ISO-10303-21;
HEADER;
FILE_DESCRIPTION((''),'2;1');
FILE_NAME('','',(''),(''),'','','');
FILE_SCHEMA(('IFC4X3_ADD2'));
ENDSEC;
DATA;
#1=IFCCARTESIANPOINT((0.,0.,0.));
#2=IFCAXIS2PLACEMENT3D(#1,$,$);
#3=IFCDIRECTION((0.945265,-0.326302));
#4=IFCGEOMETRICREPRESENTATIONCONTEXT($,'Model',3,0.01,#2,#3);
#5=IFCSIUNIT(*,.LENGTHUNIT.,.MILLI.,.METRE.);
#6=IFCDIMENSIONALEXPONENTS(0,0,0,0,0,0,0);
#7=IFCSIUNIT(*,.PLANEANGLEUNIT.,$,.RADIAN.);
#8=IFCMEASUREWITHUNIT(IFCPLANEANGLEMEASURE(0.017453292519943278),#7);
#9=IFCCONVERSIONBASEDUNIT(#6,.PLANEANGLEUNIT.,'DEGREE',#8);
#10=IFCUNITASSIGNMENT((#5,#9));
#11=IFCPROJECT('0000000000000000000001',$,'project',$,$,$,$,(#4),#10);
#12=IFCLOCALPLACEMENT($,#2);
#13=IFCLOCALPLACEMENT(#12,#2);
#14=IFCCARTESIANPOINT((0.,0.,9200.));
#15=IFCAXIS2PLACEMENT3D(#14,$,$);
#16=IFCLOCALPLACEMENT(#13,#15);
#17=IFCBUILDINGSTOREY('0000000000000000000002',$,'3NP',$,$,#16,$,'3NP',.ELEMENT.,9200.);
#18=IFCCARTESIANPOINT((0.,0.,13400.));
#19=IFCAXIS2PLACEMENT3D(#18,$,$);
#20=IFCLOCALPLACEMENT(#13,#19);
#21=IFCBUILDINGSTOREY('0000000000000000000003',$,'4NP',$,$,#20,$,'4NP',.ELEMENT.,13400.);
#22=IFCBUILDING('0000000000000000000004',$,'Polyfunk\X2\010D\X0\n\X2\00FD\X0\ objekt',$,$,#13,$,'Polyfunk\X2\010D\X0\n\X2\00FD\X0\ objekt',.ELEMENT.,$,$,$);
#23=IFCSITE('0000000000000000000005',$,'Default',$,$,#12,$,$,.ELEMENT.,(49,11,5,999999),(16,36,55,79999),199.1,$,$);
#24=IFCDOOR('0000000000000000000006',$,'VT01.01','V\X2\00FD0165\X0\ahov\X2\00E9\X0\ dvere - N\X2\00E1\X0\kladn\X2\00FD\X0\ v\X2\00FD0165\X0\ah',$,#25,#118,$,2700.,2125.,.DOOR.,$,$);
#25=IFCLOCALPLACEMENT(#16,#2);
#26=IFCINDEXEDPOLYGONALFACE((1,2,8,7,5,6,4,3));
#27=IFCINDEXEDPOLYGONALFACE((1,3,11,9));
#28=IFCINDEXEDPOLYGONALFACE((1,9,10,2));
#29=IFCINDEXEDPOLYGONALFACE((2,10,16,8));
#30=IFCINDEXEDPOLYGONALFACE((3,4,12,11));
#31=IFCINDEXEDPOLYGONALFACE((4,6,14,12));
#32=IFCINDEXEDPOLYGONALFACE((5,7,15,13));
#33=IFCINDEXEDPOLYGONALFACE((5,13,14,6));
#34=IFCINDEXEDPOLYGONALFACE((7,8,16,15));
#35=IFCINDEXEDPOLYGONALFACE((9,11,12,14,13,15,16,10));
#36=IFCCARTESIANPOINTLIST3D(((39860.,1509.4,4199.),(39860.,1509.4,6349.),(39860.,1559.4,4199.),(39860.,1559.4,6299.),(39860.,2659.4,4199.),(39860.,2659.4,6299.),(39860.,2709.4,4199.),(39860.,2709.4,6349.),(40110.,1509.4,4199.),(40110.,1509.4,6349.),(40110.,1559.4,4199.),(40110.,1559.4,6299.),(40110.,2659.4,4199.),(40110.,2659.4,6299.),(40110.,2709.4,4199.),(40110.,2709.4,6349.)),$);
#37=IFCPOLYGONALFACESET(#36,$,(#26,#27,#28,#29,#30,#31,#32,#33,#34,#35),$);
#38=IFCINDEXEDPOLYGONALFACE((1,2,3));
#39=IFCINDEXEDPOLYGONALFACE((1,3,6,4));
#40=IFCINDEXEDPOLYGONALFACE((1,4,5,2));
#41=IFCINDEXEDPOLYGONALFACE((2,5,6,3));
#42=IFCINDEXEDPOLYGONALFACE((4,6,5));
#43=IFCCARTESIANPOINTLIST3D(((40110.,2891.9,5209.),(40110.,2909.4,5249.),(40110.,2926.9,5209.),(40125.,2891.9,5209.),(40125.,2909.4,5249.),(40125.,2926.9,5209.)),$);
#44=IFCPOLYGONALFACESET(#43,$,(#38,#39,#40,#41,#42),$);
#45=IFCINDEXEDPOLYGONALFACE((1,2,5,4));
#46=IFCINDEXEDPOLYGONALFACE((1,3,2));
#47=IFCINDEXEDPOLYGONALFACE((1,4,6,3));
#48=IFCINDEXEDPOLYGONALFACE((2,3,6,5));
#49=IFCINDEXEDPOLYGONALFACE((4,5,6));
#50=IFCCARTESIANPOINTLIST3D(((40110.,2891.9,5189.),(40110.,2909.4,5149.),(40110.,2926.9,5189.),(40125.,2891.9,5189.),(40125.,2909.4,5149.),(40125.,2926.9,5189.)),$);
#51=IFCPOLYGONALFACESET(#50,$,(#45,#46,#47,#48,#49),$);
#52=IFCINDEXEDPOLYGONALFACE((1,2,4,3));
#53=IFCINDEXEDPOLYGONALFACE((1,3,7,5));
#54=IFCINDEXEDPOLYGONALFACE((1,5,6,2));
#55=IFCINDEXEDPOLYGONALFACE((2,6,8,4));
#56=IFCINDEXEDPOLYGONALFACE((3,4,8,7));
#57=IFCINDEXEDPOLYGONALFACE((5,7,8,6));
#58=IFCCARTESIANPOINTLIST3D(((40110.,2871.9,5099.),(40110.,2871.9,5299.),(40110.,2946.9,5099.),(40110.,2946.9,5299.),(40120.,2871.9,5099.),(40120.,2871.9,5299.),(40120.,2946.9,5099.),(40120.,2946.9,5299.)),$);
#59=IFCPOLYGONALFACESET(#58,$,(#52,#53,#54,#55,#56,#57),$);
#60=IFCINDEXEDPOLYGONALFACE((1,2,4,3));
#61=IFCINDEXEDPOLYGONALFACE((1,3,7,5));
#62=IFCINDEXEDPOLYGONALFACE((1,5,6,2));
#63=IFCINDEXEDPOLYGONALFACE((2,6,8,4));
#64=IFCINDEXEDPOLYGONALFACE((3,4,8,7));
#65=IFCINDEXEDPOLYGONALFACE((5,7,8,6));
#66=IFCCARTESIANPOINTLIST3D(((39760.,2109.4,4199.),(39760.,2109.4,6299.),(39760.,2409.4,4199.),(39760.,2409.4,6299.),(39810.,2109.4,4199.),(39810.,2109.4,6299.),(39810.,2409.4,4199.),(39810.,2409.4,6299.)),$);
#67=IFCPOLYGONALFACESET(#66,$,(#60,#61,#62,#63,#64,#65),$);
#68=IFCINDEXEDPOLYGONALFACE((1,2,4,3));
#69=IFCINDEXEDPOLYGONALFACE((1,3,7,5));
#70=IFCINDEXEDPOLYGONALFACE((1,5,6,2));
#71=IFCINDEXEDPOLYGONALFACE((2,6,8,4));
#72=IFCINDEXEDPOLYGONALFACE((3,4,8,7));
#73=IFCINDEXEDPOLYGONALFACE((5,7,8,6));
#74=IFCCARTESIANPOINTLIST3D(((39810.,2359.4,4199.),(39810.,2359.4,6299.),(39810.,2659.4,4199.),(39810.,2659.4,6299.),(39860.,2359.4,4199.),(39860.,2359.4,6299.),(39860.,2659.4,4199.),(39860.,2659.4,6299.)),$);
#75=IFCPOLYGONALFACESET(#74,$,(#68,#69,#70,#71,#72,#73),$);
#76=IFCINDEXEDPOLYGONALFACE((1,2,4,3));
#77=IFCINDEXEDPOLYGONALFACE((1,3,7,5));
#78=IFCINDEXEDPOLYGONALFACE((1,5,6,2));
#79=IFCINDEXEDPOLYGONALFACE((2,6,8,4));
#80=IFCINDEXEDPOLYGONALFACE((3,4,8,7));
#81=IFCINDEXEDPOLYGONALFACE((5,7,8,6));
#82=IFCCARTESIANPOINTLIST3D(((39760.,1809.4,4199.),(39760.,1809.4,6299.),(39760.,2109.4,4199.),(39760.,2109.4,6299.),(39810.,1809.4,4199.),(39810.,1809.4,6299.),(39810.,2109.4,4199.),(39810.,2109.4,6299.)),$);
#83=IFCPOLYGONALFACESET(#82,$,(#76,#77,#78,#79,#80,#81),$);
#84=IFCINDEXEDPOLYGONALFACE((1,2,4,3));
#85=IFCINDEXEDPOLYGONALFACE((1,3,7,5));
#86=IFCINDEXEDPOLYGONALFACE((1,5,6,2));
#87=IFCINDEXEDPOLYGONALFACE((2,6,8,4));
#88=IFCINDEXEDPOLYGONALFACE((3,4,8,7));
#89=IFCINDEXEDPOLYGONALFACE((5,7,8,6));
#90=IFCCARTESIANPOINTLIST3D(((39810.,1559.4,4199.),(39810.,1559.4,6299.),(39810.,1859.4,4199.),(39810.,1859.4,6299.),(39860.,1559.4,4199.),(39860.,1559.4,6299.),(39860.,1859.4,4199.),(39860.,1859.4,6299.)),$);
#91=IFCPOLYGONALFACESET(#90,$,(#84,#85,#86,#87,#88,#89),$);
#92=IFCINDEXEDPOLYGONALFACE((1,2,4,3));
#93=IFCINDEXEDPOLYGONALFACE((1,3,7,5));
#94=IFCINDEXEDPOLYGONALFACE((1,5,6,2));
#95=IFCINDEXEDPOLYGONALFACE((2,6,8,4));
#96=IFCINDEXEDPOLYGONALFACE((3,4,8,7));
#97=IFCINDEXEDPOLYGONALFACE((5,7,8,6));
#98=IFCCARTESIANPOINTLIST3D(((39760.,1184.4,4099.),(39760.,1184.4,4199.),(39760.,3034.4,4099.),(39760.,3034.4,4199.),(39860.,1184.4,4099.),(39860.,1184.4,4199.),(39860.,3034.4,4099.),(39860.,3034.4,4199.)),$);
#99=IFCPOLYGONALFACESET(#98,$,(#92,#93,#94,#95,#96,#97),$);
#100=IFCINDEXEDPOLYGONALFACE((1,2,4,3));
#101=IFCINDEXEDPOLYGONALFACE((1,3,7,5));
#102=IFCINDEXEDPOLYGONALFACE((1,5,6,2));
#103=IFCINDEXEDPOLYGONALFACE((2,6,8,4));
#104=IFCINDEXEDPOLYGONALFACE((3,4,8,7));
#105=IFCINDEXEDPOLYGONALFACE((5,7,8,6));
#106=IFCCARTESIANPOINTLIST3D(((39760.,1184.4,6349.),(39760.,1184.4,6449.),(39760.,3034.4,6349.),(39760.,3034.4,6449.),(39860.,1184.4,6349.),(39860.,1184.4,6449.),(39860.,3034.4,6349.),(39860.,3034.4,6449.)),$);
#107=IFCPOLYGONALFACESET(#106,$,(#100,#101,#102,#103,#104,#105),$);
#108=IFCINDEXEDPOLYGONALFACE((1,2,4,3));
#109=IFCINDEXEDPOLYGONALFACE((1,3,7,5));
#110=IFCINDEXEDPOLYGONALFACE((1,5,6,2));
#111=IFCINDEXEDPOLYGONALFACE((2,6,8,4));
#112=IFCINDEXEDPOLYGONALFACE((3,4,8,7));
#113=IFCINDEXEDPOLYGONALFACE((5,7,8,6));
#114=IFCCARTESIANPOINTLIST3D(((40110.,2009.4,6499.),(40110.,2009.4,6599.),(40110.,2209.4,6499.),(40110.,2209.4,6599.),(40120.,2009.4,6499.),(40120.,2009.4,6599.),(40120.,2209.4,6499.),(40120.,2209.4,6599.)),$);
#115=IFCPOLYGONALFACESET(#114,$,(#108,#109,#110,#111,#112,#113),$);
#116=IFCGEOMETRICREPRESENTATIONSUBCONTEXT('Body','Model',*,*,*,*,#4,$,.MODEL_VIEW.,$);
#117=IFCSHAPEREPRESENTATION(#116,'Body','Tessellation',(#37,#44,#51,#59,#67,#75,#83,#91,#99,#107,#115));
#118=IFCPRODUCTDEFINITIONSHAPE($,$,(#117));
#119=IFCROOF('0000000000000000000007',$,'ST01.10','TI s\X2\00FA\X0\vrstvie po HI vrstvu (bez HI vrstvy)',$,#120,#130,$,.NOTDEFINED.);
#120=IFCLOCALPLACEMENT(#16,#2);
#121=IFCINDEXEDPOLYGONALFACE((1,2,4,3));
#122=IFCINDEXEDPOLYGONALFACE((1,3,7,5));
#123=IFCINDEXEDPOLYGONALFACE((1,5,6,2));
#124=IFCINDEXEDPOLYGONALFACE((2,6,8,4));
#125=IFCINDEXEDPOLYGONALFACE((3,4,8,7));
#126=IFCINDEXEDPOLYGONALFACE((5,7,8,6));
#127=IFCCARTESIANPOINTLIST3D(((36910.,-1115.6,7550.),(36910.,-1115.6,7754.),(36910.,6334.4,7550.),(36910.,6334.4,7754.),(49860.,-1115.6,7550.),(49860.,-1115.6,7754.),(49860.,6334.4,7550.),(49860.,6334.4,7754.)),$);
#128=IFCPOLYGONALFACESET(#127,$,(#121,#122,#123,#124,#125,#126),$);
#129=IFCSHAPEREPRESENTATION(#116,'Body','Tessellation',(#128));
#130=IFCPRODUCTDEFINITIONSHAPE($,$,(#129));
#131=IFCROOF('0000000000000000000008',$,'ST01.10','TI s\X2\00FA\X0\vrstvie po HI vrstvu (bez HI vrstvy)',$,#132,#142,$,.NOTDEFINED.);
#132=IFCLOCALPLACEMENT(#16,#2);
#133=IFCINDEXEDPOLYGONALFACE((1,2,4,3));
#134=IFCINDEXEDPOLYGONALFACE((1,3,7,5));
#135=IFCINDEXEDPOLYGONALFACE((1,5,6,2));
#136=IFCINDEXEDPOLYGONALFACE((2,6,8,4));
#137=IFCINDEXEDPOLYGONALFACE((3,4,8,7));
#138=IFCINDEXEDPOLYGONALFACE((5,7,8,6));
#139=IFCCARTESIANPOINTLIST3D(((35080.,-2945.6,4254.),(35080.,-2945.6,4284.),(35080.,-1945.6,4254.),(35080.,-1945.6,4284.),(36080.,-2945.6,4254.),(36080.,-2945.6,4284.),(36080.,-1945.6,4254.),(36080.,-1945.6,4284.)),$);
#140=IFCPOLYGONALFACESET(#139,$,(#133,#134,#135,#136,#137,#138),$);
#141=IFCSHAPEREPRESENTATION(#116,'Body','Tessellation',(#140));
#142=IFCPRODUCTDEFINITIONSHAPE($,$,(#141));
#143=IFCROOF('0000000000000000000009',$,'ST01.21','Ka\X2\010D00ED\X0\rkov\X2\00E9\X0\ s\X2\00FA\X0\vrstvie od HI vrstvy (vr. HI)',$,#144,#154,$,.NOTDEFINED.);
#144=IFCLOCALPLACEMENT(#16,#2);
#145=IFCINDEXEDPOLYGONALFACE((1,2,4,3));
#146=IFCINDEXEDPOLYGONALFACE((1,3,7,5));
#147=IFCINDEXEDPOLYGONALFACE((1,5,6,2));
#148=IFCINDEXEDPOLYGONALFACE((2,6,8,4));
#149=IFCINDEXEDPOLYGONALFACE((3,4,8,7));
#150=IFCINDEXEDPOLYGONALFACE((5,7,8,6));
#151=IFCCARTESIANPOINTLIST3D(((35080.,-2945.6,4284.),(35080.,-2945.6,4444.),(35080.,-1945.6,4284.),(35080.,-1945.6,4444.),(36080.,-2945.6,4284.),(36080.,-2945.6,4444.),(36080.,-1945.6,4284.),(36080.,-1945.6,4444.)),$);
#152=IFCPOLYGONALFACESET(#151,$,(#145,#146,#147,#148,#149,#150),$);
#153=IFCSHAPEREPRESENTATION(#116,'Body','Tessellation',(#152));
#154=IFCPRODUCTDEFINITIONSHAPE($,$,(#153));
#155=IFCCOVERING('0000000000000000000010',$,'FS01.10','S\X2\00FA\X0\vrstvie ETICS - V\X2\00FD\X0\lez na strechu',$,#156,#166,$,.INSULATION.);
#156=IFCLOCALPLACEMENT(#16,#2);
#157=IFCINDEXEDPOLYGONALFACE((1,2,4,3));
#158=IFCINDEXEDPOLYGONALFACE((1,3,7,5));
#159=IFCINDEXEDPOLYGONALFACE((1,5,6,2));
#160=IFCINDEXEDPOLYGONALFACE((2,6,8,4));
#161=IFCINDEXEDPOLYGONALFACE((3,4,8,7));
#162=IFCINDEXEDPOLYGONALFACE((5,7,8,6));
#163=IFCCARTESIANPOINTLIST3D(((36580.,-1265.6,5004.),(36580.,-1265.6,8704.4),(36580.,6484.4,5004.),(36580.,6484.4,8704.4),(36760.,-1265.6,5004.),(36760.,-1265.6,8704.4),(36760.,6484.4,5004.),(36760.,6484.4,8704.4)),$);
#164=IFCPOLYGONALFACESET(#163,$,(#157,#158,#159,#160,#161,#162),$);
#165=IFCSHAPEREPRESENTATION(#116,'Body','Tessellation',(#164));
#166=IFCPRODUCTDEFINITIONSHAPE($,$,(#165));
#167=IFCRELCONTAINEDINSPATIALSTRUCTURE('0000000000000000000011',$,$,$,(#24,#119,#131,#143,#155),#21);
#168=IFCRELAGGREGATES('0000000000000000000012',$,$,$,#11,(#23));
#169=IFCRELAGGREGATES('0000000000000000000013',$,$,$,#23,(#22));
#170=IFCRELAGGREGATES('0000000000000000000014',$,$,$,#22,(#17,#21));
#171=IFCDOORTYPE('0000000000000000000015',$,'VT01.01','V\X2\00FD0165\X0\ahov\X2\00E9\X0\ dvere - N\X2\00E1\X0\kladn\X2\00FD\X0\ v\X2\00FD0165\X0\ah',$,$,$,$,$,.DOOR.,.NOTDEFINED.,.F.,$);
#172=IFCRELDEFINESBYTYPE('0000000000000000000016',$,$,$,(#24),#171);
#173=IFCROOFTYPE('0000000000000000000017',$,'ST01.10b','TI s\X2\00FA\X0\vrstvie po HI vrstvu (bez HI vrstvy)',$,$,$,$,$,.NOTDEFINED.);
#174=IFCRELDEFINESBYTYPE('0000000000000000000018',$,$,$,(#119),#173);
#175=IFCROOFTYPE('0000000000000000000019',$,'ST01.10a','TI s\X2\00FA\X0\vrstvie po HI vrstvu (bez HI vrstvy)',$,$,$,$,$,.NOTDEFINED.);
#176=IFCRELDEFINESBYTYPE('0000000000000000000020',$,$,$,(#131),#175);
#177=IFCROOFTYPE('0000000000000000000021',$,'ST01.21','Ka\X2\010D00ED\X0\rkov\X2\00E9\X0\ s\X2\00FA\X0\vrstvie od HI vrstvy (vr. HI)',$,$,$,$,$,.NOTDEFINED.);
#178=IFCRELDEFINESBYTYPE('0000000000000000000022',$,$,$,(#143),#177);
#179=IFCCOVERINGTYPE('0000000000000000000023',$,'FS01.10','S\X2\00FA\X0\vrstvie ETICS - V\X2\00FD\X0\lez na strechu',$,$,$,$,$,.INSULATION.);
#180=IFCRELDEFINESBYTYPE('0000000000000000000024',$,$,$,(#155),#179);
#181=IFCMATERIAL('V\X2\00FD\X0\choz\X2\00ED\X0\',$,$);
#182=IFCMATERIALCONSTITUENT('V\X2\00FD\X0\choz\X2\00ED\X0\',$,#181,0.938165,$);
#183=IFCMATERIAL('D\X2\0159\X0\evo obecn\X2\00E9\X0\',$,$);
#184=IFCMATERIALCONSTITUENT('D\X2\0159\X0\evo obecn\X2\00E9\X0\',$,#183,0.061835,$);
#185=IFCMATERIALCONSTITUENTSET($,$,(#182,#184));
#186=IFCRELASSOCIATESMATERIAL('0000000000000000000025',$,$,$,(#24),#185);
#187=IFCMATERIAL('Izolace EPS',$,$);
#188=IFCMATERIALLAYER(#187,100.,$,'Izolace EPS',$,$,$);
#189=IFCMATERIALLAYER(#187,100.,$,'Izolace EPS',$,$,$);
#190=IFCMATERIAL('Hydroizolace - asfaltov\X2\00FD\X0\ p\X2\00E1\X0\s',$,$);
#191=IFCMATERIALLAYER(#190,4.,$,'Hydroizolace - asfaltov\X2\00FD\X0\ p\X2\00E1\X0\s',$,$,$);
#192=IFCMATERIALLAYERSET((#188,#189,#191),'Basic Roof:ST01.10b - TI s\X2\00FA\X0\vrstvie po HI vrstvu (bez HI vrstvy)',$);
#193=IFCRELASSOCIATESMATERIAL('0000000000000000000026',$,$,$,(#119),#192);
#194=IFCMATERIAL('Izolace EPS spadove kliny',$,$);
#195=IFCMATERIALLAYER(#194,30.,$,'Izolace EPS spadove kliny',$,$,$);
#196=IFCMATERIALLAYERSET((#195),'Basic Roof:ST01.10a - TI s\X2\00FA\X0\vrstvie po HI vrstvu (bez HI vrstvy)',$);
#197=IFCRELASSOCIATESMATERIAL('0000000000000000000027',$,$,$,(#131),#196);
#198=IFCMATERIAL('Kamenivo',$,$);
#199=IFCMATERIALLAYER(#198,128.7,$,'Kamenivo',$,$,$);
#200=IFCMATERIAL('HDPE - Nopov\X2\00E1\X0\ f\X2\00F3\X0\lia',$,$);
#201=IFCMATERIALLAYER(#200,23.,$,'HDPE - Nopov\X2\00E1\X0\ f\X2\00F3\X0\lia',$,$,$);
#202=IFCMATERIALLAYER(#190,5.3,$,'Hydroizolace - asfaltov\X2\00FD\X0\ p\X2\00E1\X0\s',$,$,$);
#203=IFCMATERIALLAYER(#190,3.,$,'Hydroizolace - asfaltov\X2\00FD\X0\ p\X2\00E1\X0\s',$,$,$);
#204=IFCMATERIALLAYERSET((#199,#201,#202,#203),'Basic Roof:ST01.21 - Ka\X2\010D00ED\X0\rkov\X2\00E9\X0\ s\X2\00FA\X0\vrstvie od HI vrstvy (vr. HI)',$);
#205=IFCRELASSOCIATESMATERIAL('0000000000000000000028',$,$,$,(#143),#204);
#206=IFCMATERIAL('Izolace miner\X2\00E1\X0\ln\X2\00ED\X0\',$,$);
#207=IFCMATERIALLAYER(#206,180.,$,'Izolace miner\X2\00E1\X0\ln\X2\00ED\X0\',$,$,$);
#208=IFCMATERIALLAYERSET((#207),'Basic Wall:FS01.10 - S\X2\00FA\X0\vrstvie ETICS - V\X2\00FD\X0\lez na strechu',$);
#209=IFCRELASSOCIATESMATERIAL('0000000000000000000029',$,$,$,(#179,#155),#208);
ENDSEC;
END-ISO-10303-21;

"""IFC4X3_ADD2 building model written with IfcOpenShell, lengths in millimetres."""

from ifc_helpers import new_model, entity, si_unit, converted_unit, direction, frame, frame_2d, origin, origin_2d_with_axis, place, context, subcontext, project, spatial, polyline, rectangle, outline, extrude, source, transform, mapped, material, layer, layer_set, constituent, constituent_set, type_object, type_shapes, element, save


model = new_model("IFC4X3_ADD2")

# Units and contexts
model_context = context("Model", 3, precision=0.01, world=origin(), true_north=direction((0.945265, -0.326302)))
body_context = subcontext(model_context, "Body", "Model", "MODEL_VIEW")
ifc_project = project(units=[si_unit("LENGTHUNIT", "METRE", prefix="MILLI"), converted_unit("PLANEANGLEUNIT", "DEGREE", entity("IfcPlaneAngleMeasure", 0.017453292519943278), si_unit("PLANEANGLEUNIT", "RADIAN"), dimensions=[0, 0, 0, 0, 0, 0, 0])], contexts=[model_context])

# Site, building, storey
site_placement = place(None, origin())
site = spatial("IfcSite", under=ifc_project, at=site_placement, Name="Default", CompositionType="ELEMENT", RefLatitude=(49, 11, 5, 999999), RefLongitude=(16, 36, 55, 79999), RefElevation=199.1)
building_placement = place(site_placement, origin())
building = spatial("IfcBuilding", under=site, at=building_placement, Name="Polyfunkčný objekt", LongName="Polyfunkčný objekt", CompositionType="ELEMENT")
storey_1_placement = place(building_placement, frame((0.0, 0.0, 9200.0)))
storey_1 = spatial("IfcBuildingStorey", under=building, at=storey_1_placement, Name="3NP", LongName="3NP", CompositionType="ELEMENT", Elevation=9200.0)

# Shared definitions
storey_2_placement = place(building_placement, frame((0.0, 0.0, 13400.0)))
storey_2 = spatial("IfcBuildingStorey", under=building, at=storey_2_placement, Name="4NP", LongName="4NP", CompositionType="ELEMENT", Elevation=13400.0)

# Shared definitions
ifc_material_1 = material(Name="HDPE - Nopová fólia")
ifc_material_2 = material(Name="Hydroizolace - asfaltový pás")
ifc_material_3 = material(Name="Izolace EPS spadove kliny")
ifc_layer_1 = layer(ifc_material_3, 30.0, Name="Izolace EPS spadove kliny")
ifc_layer_set_1 = layer_set([ifc_layer_1], Name="Basic Roof:ST01.10a - TI súvrstvie po HI vrstvu (bez HI vrstvy)")
ifc_material_4 = material(Name="Kamenivo")
ifc_layer_2 = layer(ifc_material_4, 128.7, Name="Kamenivo")
ifc_layer_3 = layer(ifc_material_1, 23.0, Name="HDPE - Nopová fólia")
ifc_layer_4 = layer(ifc_material_2, 5.3, Name="Hydroizolace - asfaltový pás")
ifc_layer_5 = layer(ifc_material_2, 3.0, Name="Hydroizolace - asfaltový pás")
ifc_layer_set_2 = layer_set([ifc_layer_2, ifc_layer_3, ifc_layer_4, ifc_layer_5], Name="Basic Roof:ST01.21 - Kačírkové súvrstvie od HI vrstvy (vr. HI)")

# Shared definitions
ifc_material_5 = material(Name="Izolace minerální")

# Door
ifc_material_6 = material(Name="Výchozí")
ifc_constituent_1 = constituent(ifc_material_6, Name="Výchozí", fraction=0.938165)
ifc_material_7 = material(Name="Dřevo obecné")
ifc_constituent_2 = constituent(ifc_material_7, Name="Dřevo obecné", fraction=0.061835)
ifc_constituent_set = constituent_set(constituents=[ifc_constituent_1, ifc_constituent_2])
door_type = type_object("IfcDoorType", Name="VT01.01", Description="Výťahové dvere - Nákladný výťah", OperationType="NOTDEFINED", ParameterTakesPrecedence=False, PredefinedType="DOOR")
shared_shape_1 = source(origin(), body_context, "Body", "SweptSolid", [
    extrude(outline(polyline([(-1087.5, -600.0), (1062.5, -600.0), (1062.5, -550.0), (-1037.5, -550.0), (-1037.5, 550.0), (1062.5, 550.0), (1062.5, 600.0), (-1087.5, 600.0), (-1087.5, -600.0)])), frame((600.0, 0.0, 1062.5), z_axis=(0.0, 1.0, 0.0), x_axis=(0.0, 0.0, -1.0)), (0.0, 0.0, 1.0), 250.0),
    extrude(outline(polyline([(-24.4, -10.7), (19.2, -10.7), (5.2, 21.4), (-24.4, -10.7)])), frame((1400.0, -15.0, 1023.3), z_axis=(0.0, 1.0, 0.0), x_axis=(0.400819, 0.0, -0.916157)), (0.0, 0.0, 1.0), 15.0),
    extrude(outline(polyline([(-24.4, -10.7), (19.2, -10.7), (5.2, 21.4), (-24.4, -10.7)])), frame((1400.0, -15.0, 976.7), z_axis=(0.0, 1.0, 0.0), x_axis=(-0.400819, 0.0, 0.916157)), (0.0, 0.0, 1.0), 15.0),
    extrude(rectangle(XDim=10.0, YDim=75.0, at=frame_2d((0.0, 0.0), x_axis=(1.0, 0.0))), frame((1400.0, -5.0, 900.0), z_axis=(0.0, 0.0, 1.0), x_axis=(0.0, 1.0, 0.0)), (0.0, 0.0, 1.0), 200.0),
    extrude(rectangle(XDim=50.0, YDim=300.0, at=origin_2d_with_axis()), frame((750.0, 325.0, 0.0), z_axis=(0.0, 0.0, 1.0), x_axis=(0.0, -1.0, 0.0)), (0.0, 0.0, 1.0), 2100.0),
    extrude(rectangle(XDim=50.0, YDim=300.0, at=frame_2d((0.0, 0.0), x_axis=(1.0, 0.0))), frame((1000.0, 275.0, 0.0), z_axis=(0.0, 0.0, 1.0), x_axis=(0.0, -1.0, 0.0)), (0.0, 0.0, 1.0), 2100.0),
    extrude(rectangle(XDim=300.0, YDim=50.0, at=frame_2d((0.0, 0.0), x_axis=(1.0, 0.0))), frame((450.0, 325.0, 0.0), z_axis=(0.0, 0.0, 1.0), x_axis=(-1.0, 0.0, 0.0)), (0.0, 0.0, 1.0), 2100.0),
    extrude(rectangle(XDim=300.0, YDim=50.0, at=frame_2d((0.0, 0.0), x_axis=(1.0, 0.0))), frame((200.0, 275.0, 0.0), z_axis=(0.0, 0.0, 1.0), x_axis=(-1.0, 0.0, 0.0)), (0.0, 0.0, 1.0), 2100.0),
    extrude(rectangle(XDim=1850.0, YDim=100.0, at=frame_2d((0.0, 0.0), x_axis=(1.0, 0.0))), frame((600.0, 300.0, -100.0), z_axis=(0.0, 0.0, 1.0), x_axis=(-1.0, 0.0, 0.0)), (0.0, 0.0, 1.0), 100.0),
    extrude(rectangle(XDim=1850.0, YDim=100.0, at=frame_2d((0.0, 0.0), x_axis=(1.0, 0.0))), frame((600.0, 300.0, 2150.0), z_axis=(0.0, 0.0, 1.0), x_axis=(-1.0, 0.0, 0.0)), (0.0, 0.0, 1.0), 100.0),
    extrude(rectangle(XDim=10.0, YDim=200.0, at=frame_2d((0.0, 0.0), x_axis=(1.0, 0.0))), frame((600.0, -5.0, 2300.0), z_axis=(0.0, 0.0, 1.0), x_axis=(0.0, 1.0, 0.0)), (0.0, 0.0, 1.0), 100.0),
])
type_shapes(door_type, [shared_shape_1])
door_placement = place(storey_2_placement, frame((40110.0, 1509.4, -1.0), z_axis=(0.0, 0.0, 1.0), x_axis=(0.0, 1.0, 0.0)))
element("IfcDoor", 1, at=door_placement, inside=storey_2, type_object=door_type, material=ifc_constituent_set, Name="VT01.01", Description="Výťahové dvere - Nákladný výťah", OverallHeight=2700.0, OverallWidth=2125.0, PredefinedType="DOOR", context=body_context, shape_type="MappedRepresentation", body=[
    mapped(shared_shape_1, transform((0.0, 0.0, 0.0), scale=1.0)),
])

# Roofs
ifc_material_8 = material(Name="Izolace EPS")
ifc_layer_6 = layer(ifc_material_8, 100.0, Name="Izolace EPS")
ifc_layer_7 = layer(ifc_material_8, 100.0, Name="Izolace EPS")
ifc_layer_8 = layer(ifc_material_2, 4.0, Name="Hydroizolace - asfaltový pás")
ifc_layer_set_3 = layer_set([ifc_layer_6, ifc_layer_7, ifc_layer_8], Name="Basic Roof:ST01.10b - TI súvrstvie po HI vrstvu (bez HI vrstvy)")
roof_type_1 = type_object("IfcRoofType", Name="ST01.10b", Description="TI súvrstvie po HI vrstvu (bez HI vrstvy)", PredefinedType="NOTDEFINED")
roof_1_placement = place(storey_2_placement, frame((36910.0, -1115.6, 3350.0)))
element("IfcRoof", 2, at=roof_1_placement, inside=storey_2, type_object=roof_type_1, material=ifc_layer_set_3, Name="ST01.10", Description="TI súvrstvie po HI vrstvu (bez HI vrstvy)", PredefinedType="NOTDEFINED", context=body_context, shape_type="SweptSolid", body=[
    extrude(rectangle(XDim=7450.0, YDim=12950.0, at=origin_2d_with_axis()), frame((6475.0, 3725.0, 0.0), z_axis=(0.0, 0.0, 1.0), x_axis=(0.0, -1.0, 0.0)), (0.0, 0.0, 1.0), 204.0),
])
roof_type_2 = type_object("IfcRoofType", Name="ST01.10a", Description="TI súvrstvie po HI vrstvu (bez HI vrstvy)", PredefinedType="NOTDEFINED")
roof_2_placement = place(storey_2_placement, frame((35080.0, -2945.6, 54.0)))
element("IfcRoof", 3, at=roof_2_placement, inside=storey_2, type_object=roof_type_2, material=ifc_layer_set_1, Name="ST01.10", Description="TI súvrstvie po HI vrstvu (bez HI vrstvy)", PredefinedType="NOTDEFINED", context=body_context, shape_type="SweptSolid", body=[
    extrude(rectangle(XDim=1000.0, YDim=1000.0, at=frame_2d((0.0, 0.0), x_axis=(1.0, 0.0))), frame((500.0, 500.0, 0.0), z_axis=(0.0, 0.0, 1.0), x_axis=(0.0, 1.0, 0.0)), (0.0, 0.0, 1.0), 30.0),
])
roof_type_3 = type_object("IfcRoofType", Name="ST01.21", Description="Kačírkové súvrstvie od HI vrstvy (vr. HI)", PredefinedType="NOTDEFINED")
roof_3_placement = place(storey_2_placement, frame((35080.0, -2945.6, 84.0)))
element("IfcRoof", 4, at=roof_3_placement, inside=storey_2, type_object=roof_type_3, material=ifc_layer_set_2, Name="ST01.21", Description="Kačírkové súvrstvie od HI vrstvy (vr. HI)", PredefinedType="NOTDEFINED", context=body_context, shape_type="SweptSolid", body=[
    extrude(rectangle(XDim=1000.0, YDim=1000.0, at=origin_2d_with_axis()), frame((500.0, 500.0, 0.0), z_axis=(0.0, 0.0, 1.0), x_axis=(0.0, -1.0, 0.0)), (0.0, 0.0, 1.0), 160.0),
])

# Covering
ifc_layer_9 = layer(ifc_material_5, 180.0, Name="Izolace minerální")
ifc_layer_set_4 = layer_set([ifc_layer_9], Name="Basic Wall:FS01.10 - Súvrstvie ETICS - Výlez na strechu")
covering_type = type_object("IfcCoveringType", Name="FS01.10", Description="Súvrstvie ETICS - Výlez na strechu", PredefinedType="INSULATION", material=ifc_layer_set_4)
covering_placement = place(storey_2_placement, frame((36670.0, -1265.6, 804.0), z_axis=(0.0, 0.0, 1.0), x_axis=(0.0, 1.0, 0.0)))
element("IfcCovering", 5, at=covering_placement, inside=storey_2, type_object=covering_type, material=ifc_layer_set_4, Name="FS01.10", Description="Súvrstvie ETICS - Výlez na strechu", PredefinedType="INSULATION", context=body_context, shape_type="SweptSolid", body=[
    extrude(rectangle(XDim=7750.0, YDim=180.0, at=frame_2d((3875.0, 0.0), x_axis=(-1.0, 0.0))), origin(), (0.0, 0.0, 1.0), 3700.4),
])

save(model, "model.ifc")
